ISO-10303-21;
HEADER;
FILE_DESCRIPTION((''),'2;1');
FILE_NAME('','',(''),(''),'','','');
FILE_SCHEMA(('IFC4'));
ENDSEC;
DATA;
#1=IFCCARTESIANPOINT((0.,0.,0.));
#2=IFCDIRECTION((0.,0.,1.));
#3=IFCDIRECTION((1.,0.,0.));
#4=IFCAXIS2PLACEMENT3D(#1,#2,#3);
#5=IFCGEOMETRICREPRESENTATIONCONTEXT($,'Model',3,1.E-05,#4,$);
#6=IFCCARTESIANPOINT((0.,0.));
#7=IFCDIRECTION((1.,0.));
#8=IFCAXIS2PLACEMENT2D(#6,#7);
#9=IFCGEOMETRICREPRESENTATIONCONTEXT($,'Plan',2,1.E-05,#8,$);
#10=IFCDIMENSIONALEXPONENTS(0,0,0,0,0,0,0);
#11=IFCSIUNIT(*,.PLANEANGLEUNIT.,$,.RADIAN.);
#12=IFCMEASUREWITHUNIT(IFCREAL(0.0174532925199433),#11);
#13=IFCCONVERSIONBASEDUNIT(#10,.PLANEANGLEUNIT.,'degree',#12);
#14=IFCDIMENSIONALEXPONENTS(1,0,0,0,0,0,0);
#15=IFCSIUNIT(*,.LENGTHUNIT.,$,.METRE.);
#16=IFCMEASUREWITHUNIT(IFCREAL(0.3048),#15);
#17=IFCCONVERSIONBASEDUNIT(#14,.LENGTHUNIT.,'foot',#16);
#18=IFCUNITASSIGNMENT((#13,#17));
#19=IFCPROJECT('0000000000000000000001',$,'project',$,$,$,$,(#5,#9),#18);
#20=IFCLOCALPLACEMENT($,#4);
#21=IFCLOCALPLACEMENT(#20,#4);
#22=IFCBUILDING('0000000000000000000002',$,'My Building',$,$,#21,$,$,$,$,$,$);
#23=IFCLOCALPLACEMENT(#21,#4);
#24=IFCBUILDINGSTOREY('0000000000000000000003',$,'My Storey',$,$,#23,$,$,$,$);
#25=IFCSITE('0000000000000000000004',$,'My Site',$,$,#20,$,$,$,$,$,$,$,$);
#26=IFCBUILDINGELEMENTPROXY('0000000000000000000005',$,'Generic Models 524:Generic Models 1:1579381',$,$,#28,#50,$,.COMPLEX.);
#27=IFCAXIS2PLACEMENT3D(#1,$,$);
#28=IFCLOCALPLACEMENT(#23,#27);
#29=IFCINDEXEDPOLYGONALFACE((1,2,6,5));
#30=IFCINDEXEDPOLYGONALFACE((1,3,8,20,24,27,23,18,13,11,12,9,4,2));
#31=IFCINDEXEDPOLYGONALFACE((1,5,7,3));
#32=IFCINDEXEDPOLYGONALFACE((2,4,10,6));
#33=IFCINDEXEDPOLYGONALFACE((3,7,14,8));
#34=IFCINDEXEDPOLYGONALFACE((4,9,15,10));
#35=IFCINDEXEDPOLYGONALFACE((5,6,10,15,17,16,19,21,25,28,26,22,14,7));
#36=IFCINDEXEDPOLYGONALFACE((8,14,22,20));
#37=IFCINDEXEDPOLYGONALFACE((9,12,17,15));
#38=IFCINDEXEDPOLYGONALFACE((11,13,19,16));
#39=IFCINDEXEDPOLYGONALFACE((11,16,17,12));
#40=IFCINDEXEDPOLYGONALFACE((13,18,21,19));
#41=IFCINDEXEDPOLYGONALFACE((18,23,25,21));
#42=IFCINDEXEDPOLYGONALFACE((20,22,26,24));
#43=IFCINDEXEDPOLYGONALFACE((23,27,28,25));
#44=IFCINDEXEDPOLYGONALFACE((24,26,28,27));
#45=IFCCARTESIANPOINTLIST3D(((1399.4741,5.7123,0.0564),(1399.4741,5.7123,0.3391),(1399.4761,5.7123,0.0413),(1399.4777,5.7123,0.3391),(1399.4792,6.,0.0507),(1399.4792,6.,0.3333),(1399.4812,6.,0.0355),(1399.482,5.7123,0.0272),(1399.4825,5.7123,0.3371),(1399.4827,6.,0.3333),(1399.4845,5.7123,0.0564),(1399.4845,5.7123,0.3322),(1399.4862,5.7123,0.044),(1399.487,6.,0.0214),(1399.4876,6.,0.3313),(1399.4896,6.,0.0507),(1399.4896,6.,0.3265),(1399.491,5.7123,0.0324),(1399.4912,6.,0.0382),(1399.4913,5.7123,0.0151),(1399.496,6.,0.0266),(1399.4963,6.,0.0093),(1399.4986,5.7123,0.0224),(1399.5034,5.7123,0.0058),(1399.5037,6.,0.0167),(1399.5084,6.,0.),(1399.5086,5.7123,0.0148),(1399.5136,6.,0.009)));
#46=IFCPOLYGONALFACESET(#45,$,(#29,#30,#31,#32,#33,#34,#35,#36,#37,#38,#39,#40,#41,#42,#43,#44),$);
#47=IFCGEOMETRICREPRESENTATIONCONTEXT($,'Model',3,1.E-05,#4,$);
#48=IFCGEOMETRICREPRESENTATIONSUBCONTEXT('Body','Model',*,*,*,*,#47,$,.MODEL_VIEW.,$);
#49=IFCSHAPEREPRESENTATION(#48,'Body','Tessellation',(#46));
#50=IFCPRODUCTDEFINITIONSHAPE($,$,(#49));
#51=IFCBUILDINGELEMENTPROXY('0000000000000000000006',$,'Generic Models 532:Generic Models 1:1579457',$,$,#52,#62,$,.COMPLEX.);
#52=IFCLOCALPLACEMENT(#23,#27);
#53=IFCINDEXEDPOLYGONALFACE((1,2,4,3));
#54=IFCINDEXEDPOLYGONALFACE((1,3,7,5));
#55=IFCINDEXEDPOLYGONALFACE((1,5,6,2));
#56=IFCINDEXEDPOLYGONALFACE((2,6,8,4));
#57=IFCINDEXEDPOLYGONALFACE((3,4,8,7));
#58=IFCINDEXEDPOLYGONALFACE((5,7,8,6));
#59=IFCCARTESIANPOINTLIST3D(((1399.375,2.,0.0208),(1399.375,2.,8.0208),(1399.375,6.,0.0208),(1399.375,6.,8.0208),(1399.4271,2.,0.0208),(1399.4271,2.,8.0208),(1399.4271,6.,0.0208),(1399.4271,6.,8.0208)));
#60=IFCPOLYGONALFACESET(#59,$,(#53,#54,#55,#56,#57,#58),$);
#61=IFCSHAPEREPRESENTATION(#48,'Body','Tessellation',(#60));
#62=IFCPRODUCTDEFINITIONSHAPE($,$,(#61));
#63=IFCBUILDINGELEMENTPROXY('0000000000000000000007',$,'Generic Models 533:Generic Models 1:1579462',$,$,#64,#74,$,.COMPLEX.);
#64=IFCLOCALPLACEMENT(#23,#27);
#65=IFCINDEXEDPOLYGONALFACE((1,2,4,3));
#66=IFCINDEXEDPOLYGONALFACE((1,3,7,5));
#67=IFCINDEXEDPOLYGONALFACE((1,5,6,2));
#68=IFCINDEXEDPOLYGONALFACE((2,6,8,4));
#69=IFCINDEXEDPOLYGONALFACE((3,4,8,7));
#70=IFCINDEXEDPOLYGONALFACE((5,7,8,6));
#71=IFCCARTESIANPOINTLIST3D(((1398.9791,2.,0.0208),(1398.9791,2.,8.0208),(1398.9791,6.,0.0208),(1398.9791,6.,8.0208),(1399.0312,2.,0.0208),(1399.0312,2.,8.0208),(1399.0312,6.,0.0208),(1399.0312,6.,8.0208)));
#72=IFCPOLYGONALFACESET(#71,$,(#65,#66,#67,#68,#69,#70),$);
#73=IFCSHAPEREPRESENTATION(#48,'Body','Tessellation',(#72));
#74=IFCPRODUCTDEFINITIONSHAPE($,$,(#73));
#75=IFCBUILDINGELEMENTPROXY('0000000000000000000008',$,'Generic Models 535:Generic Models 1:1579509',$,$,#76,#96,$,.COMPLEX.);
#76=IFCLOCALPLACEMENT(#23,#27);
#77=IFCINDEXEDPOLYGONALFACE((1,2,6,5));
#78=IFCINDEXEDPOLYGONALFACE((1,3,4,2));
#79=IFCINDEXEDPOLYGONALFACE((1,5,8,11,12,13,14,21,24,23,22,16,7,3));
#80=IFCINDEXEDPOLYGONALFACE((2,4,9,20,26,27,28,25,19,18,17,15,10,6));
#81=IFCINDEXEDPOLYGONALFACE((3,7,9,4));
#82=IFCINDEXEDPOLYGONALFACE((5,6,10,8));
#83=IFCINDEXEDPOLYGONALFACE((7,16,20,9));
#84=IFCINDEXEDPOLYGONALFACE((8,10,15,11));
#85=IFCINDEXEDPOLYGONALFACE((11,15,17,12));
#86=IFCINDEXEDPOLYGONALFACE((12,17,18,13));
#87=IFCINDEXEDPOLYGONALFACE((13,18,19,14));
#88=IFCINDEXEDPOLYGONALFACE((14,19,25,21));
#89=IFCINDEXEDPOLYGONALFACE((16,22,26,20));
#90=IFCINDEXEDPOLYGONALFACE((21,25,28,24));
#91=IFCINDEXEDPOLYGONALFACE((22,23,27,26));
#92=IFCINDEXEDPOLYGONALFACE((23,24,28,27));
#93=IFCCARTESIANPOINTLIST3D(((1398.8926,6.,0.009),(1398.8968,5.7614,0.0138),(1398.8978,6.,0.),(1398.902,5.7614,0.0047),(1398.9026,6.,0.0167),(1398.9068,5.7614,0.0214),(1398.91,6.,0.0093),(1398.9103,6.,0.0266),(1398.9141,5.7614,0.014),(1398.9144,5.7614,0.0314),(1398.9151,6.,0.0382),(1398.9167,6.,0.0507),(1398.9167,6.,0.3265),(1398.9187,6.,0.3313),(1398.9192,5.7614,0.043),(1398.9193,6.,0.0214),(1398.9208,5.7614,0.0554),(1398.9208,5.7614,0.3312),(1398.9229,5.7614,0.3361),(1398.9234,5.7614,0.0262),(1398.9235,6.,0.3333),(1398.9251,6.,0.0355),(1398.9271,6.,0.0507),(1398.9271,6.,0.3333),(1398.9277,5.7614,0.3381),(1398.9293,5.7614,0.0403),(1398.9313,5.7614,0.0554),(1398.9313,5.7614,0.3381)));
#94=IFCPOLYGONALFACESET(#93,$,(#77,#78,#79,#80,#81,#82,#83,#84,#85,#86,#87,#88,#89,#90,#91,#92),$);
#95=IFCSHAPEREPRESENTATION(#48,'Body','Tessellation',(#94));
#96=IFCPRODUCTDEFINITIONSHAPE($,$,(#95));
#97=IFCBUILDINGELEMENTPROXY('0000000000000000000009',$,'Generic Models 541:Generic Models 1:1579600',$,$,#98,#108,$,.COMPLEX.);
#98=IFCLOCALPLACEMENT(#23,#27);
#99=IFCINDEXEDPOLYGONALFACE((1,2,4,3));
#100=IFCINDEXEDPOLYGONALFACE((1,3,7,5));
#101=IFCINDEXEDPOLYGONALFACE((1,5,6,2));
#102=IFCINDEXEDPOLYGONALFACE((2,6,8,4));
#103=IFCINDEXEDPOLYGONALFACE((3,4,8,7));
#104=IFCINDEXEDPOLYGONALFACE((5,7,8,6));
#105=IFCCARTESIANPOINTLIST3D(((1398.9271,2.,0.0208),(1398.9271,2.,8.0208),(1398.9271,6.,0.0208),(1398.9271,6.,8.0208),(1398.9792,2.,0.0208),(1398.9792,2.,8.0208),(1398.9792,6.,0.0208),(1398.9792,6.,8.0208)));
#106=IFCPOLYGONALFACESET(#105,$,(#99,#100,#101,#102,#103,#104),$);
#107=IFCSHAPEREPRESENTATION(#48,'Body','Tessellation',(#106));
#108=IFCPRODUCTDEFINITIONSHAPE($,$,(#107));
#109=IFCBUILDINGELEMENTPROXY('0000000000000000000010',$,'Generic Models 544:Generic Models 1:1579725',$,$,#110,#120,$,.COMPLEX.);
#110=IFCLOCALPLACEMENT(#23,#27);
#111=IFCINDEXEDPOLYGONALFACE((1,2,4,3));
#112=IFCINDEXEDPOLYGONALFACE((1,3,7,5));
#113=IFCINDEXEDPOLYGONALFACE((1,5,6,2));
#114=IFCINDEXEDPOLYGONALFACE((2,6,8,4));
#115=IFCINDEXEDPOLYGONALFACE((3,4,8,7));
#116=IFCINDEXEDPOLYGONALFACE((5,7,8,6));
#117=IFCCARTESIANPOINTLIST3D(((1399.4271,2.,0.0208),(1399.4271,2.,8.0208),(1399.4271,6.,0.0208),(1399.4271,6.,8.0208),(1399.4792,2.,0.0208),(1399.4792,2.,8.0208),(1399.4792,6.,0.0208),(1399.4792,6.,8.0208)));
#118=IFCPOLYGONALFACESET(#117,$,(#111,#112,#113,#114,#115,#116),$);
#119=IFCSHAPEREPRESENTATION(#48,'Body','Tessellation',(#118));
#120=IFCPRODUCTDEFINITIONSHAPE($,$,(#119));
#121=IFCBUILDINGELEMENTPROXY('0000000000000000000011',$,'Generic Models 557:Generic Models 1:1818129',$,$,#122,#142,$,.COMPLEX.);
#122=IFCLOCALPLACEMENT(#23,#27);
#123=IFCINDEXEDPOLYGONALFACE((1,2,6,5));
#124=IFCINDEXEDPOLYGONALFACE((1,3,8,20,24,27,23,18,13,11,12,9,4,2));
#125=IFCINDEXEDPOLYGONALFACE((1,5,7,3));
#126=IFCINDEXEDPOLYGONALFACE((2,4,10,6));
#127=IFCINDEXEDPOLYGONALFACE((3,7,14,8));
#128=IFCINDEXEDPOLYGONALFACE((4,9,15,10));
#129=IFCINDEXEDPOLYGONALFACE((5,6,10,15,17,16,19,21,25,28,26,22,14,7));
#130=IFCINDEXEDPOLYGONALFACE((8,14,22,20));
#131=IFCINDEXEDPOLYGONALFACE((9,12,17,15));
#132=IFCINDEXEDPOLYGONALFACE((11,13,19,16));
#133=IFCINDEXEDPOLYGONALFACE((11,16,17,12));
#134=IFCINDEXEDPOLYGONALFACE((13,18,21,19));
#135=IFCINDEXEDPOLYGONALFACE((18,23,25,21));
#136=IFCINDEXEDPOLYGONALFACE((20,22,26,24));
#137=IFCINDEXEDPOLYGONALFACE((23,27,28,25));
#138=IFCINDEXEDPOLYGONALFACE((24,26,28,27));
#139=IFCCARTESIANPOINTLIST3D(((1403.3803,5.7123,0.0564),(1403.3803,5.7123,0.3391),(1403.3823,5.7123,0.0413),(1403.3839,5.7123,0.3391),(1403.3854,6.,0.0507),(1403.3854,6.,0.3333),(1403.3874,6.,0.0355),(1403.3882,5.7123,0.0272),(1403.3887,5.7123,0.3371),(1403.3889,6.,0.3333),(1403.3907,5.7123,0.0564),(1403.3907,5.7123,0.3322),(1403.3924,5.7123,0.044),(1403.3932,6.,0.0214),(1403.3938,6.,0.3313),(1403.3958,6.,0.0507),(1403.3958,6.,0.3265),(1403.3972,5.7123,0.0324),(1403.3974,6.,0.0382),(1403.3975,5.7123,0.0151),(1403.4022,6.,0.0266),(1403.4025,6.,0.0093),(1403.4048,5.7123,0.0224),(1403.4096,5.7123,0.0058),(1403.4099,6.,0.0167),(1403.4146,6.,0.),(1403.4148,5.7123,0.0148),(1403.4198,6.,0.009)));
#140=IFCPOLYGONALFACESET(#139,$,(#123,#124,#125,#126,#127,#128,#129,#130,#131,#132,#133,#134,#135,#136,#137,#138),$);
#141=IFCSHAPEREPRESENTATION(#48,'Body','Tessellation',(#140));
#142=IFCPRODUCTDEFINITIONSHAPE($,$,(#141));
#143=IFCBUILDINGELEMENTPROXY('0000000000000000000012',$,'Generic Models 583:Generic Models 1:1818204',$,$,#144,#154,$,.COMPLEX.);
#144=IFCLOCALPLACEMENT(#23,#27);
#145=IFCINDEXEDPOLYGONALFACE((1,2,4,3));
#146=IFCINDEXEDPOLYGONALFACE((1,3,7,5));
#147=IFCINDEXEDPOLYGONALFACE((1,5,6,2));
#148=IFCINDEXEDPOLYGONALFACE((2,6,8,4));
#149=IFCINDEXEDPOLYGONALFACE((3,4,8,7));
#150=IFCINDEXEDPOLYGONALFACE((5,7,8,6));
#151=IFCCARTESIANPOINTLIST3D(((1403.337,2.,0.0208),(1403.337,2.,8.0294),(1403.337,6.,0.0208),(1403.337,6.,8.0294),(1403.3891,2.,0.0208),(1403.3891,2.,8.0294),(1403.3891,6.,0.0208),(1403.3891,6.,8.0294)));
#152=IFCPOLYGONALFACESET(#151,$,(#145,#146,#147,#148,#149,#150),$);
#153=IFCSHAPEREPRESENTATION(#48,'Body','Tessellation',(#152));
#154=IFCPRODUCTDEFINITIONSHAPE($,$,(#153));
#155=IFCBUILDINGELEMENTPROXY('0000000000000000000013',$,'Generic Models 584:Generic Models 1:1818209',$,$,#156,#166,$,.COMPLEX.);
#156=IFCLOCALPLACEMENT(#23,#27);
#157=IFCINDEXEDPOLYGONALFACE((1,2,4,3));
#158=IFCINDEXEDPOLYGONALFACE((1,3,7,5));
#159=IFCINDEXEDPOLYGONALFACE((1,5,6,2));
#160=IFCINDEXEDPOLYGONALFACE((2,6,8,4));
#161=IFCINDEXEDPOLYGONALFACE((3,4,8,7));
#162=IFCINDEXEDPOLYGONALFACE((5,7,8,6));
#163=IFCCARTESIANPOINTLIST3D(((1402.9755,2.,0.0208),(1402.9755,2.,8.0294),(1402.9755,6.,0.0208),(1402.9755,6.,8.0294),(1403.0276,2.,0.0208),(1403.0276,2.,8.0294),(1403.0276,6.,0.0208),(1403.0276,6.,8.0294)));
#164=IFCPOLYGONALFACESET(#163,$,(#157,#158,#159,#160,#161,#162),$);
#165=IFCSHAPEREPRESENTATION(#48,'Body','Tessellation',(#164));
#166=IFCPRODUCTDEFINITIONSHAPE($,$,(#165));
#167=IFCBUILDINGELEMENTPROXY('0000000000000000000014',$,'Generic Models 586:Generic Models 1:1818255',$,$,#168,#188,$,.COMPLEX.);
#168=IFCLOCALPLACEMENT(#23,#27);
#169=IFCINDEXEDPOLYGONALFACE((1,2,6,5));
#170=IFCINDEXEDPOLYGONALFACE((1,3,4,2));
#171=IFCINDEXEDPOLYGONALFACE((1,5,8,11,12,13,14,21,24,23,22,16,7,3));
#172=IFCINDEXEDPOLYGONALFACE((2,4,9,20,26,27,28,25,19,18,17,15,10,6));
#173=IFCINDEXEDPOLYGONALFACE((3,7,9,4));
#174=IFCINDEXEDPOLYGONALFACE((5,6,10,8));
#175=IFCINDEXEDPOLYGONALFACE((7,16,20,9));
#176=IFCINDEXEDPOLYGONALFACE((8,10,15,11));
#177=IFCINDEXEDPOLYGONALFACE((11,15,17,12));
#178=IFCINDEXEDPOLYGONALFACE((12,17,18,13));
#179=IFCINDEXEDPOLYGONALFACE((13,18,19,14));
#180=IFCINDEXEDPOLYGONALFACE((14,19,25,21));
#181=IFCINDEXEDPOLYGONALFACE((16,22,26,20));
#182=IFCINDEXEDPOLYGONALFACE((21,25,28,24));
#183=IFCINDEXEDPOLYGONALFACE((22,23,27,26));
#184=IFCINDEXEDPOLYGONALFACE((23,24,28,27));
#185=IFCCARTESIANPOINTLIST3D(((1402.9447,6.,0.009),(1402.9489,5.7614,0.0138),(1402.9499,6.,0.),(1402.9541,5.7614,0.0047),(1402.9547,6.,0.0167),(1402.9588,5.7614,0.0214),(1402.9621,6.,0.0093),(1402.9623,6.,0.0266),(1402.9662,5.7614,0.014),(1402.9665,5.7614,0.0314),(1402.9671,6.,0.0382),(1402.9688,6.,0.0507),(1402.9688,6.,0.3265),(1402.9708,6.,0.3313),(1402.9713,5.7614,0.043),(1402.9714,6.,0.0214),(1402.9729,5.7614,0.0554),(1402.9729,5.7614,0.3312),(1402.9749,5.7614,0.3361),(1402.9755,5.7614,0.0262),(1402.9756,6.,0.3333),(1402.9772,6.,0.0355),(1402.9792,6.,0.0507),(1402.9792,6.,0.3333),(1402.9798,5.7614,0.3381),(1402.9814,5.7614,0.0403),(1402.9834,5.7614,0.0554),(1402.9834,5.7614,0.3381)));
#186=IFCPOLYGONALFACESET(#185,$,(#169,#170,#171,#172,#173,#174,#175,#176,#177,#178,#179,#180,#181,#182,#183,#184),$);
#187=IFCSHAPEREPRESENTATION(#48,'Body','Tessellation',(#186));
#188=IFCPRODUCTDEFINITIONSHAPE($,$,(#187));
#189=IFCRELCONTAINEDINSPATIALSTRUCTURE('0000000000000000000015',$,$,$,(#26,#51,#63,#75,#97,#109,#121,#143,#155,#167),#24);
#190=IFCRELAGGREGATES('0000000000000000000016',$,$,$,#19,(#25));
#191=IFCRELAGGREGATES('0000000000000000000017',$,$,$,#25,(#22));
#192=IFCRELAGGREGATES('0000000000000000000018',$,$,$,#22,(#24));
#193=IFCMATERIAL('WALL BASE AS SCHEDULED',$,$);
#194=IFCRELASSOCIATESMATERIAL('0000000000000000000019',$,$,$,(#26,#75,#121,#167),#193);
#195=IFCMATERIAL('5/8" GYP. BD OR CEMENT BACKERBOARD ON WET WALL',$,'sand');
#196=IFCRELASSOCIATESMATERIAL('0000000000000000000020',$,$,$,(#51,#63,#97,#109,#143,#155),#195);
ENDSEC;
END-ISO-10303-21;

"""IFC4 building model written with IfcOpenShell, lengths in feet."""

from ifc_helpers import new_model, entity, si_unit, converted_unit, frame, origin_with_axes, origin_2d_with_axis, place, context, subcontext, project, spatial, polyline, outline, extrude, material, element, save


model = new_model("IFC4")

# Units and contexts
model_context_1 = context("Model", 3, precision=1e-05, world=origin_with_axes())
plan_context = context("Plan", 2, precision=1e-05, world=origin_2d_with_axis())
model_context_2 = context("Model", 3, precision=1e-05, world=origin_with_axes())
body_context = subcontext(model_context_2, "Body", "Model", "MODEL_VIEW")
ifc_project = project(units=[converted_unit("PLANEANGLEUNIT", "degree", entity("IfcReal", 0.0174532925199433), si_unit("PLANEANGLEUNIT", "RADIAN"), dimensions=[0, 0, 0, 0, 0, 0, 0]), converted_unit("LENGTHUNIT", "foot", entity("IfcReal", 0.3048), si_unit("LENGTHUNIT", "METRE"), dimensions=[1, 0, 0, 0, 0, 0, 0])], contexts=[model_context_1, plan_context])

# Site, building, storey
site_placement = place(None, origin_with_axes())
site = spatial("IfcSite", under=ifc_project, at=site_placement, Name="My Site")
building_placement = place(site_placement, origin_with_axes())
building = spatial("IfcBuilding", under=site, at=building_placement, Name="My Building")
storey_placement = place(building_placement, origin_with_axes())
storey = spatial("IfcBuildingStorey", under=building, at=storey_placement, Name="My Storey")

# Building element proxies
ifc_material_1 = material(Name="WALL BASE AS SCHEDULED")
proxy_1_placement = place(storey_placement, frame((1399.4792, 6.0, 0.0), z_axis=(0.0, -1.0, 0.0), x_axis=(0.0, 0.0, 1.0)))
element("IfcBuildingElementProxy", 1, at=proxy_1_placement, inside=storey, material=ifc_material_1, Name="Generic Models 524:Generic Models 1:1579381", PredefinedType="COMPLEX", context=body_context, shape_type="SweptSolid", body=[
    extrude(outline(polyline([(0.0865, 0.0), (0.0968, -0.0072), (0.105, -0.0167), (0.1137, -0.0111), (0.1038, 0.0006), (0.0913, 0.0093), (0.0769, 0.0144), (0.0617, 0.0157), (-0.2206, 0.0019), (-0.2205, -0.0017), (-0.2182, -0.0064), (-0.2133, -0.0082), (0.0622, 0.0053), (0.0747, 0.0042), (0.0865, 0.0)])), frame((0.113, -0.0126, 0.0), z_axis=(0.0, 0.0, -1.0), x_axis=(-0.998808, -0.048806, 0.0)), (-0.020832, 0.016543, -0.999646), 0.2878),
])
ifc_material_2 = material(Name="5/8\" GYP. BD OR CEMENT BACKERBOARD ON WET WALL", Category="sand")
proxy_2_placement = place(storey_placement, frame((1399.375, 6.0, 0.0208), z_axis=(0.0, -1.0, 0.0), x_axis=(0.0, 0.0, 1.0)))
element("IfcBuildingElementProxy", 2, at=proxy_2_placement, inside=storey, material=ifc_material_2, Name="Generic Models 532:Generic Models 1:1579457", PredefinedType="COMPLEX", context=body_context, shape_type="SweptSolid", body=[
    extrude(outline(polyline([(-4.0, -0.026), (4.0, -0.026), (4.0, 0.026), (-4.0, 0.026), (-4.0, -0.026)])), frame((4.0, -0.026, 0.0), z_axis=(0.0, 0.0, -1.0), x_axis=(1.0, 0.0, 0.0)), (0.0, 0.0, -1.0), 4.0),
])
proxy_3_placement = place(storey_placement, frame((1398.9791, 6.0, 0.0208), z_axis=(0.0, -1.0, 0.0), x_axis=(0.0, 0.0, 1.0)))
element("IfcBuildingElementProxy", 3, at=proxy_3_placement, inside=storey, material=ifc_material_2, Name="Generic Models 533:Generic Models 1:1579462", PredefinedType="COMPLEX", context=body_context, shape_type="SweptSolid", body=[
    extrude(outline(polyline([(-0.026, -4.0), (0.026, -4.0), (0.026, 4.0), (-0.026, 4.0), (-0.026, -4.0)])), frame((4.0, -0.026, 0.0), z_axis=(0.0, 0.0, -1.0), x_axis=(0.0, -1.0, 0.0)), (0.0, 0.0, -1.0), 4.0),
])
proxy_4_placement = place(storey_placement, frame((1398.8926, 6.0, 0.0), z_axis=(0.0, -1.0, 0.0), x_axis=(0.0, 0.0, 1.0)))
element("IfcBuildingElementProxy", 4, at=proxy_4_placement, inside=storey, material=ifc_material_1, Name="Generic Models 535:Generic Models 1:1579509", PredefinedType="COMPLEX", context=body_context, shape_type="SweptSolid", body=[
    extrude(outline(polyline([(-0.2203, -0.0126), (0.0624, -0.0126), (0.0775, -0.0106), (0.0916, -0.0048), (0.1037, 0.0045), (0.113, 0.0166), (0.104, 0.0218), (0.0964, 0.0119), (0.0864, 0.0042), (0.0748, -0.0006), (0.0624, -0.0022), (-0.2134, -0.0022), (-0.2183, -0.0042), (-0.2203, -0.0091), (-0.2203, -0.0126)])), frame((0.113, -0.0218, 0.0), z_axis=(0.0, 0.0, -1.0), x_axis=(-1.0, 0.0, 0.0)), (-0.01982, -0.017382, -0.999652), 0.2387),
])
for number, where, z_axis, x_axis, name in (
    (5, (1398.9271, 6.0, 0.0208), (0.0, -1.0, 0.0), (0.0, 0.0, 1.0), "Generic Models 541:Generic Models 1:1579600"),
    (6, (1399.4271, 6.0, 0.0208), (0.0, -1.0, 0.0), (0.0, 0.0, 1.0), "Generic Models 544:Generic Models 1:1579725"),
):
    element("IfcBuildingElementProxy", number, at=place(storey_placement, frame(where, z_axis=z_axis, x_axis=x_axis)), inside=storey, material=ifc_material_2, Name=name, PredefinedType="COMPLEX", context=body_context, shape_type="SweptSolid", body=[
        extrude(outline(polyline([(-4.0, -0.026), (4.0, -0.026), (4.0, 0.026), (-4.0, 0.026), (-4.0, -0.026)])), frame((4.0, -0.026, 0.0), z_axis=(0.0, 0.0, -1.0), x_axis=(1.0, 0.0, 0.0)), (0.0, 0.0, -1.0), 4.0),
    ])
proxy_5_placement = place(storey_placement, frame((1403.3854, 6.0, 0.0), z_axis=(0.0, -1.0, 0.0), x_axis=(0.0, 0.0, 1.0)))
element("IfcBuildingElementProxy", 7, at=proxy_5_placement, inside=storey, material=ifc_material_1, Name="Generic Models 557:Generic Models 1:1818129", PredefinedType="COMPLEX", context=body_context, shape_type="SweptSolid", body=[
    extrude(outline(polyline([(0.1038, 0.0), (0.0913, 0.0088), (0.077, 0.014), (0.0618, 0.0153), (-0.2206, 0.0031), (-0.2205, -0.0005), (-0.2183, -0.0052), (-0.2133, -0.007), (0.0622, 0.0049), (0.0747, 0.0038), (0.0865, -0.0005), (0.0968, -0.0077), (0.1049, -0.0173), (0.1137, -0.0117), (0.1038, 0.0)])), frame((0.113, -0.0126, 0.0), z_axis=(0.0, 0.0, -1.0), x_axis=(-0.999059, -0.043362, 0.0)), (-0.020742, 0.016656, -0.999646), 0.2878),
])
proxy_6_placement = place(storey_placement, frame((1403.337, 6.0, 0.0208), z_axis=(0.0, -1.0, 0.0), x_axis=(0.0, 0.0, 1.0)))
element("IfcBuildingElementProxy", 8, at=proxy_6_placement, inside=storey, material=ifc_material_2, Name="Generic Models 583:Generic Models 1:1818204", PredefinedType="COMPLEX", context=body_context, shape_type="SweptSolid", body=[
    extrude(outline(polyline([(-4.0043, -0.026), (4.0043, -0.026), (4.0043, 0.026), (-4.0043, 0.026), (-4.0043, -0.026)])), frame((4.0043, -0.026, 0.0), z_axis=(0.0, 0.0, -1.0), x_axis=(-1.0, 0.0, 0.0)), (0.0, 0.0, -1.0), 4.0),
])
proxy_7_placement = place(storey_placement, frame((1402.9755, 6.0, 0.0208), z_axis=(0.0, -1.0, 0.0), x_axis=(0.0, 0.0, 1.0)))
element("IfcBuildingElementProxy", 9, at=proxy_7_placement, inside=storey, material=ifc_material_2, Name="Generic Models 584:Generic Models 1:1818209", PredefinedType="COMPLEX", context=body_context, shape_type="SweptSolid", body=[
    extrude(outline(polyline([(-0.026, -4.0043), (0.026, -4.0043), (0.026, 4.0043), (-0.026, 4.0043), (-0.026, -4.0043)])), frame((4.0043, -0.026, 0.0), z_axis=(0.0, 0.0, -1.0), x_axis=(0.0, 1.0, 0.0)), (0.0, 0.0, -1.0), 4.0),
])
proxy_8_placement = place(storey_placement, frame((1402.9447, 6.0, 0.0), z_axis=(0.0, -1.0, 0.0), x_axis=(0.0, 0.0, 1.0)))
element("IfcBuildingElementProxy", 10, at=proxy_8_placement, inside=storey, material=ifc_material_1, Name="Generic Models 586:Generic Models 1:1818255", PredefinedType="COMPLEX", context=body_context, shape_type="SweptSolid", body=[
    extrude(outline(polyline([(0.0748, 0.0), (0.0624, -0.0017), (-0.2134, -0.0039), (-0.2182, -0.0059), (-0.2202, -0.0108), (-0.2202, -0.0144), (0.0625, -0.0122), (0.0776, -0.01), (0.0917, -0.0041), (0.1037, 0.0053), (0.1129, 0.0175), (0.1039, 0.0226), (0.0963, 0.0126), (0.0864, 0.0049), (0.0748, 0.0)])), frame((0.113, -0.0218, 0.0), z_axis=(0.0, 0.0, -1.0), x_axis=(-0.99997, -0.007803, 0.0)), (-0.019684, -0.017536, -0.999652), 0.2387),
])

save(model, "model.ifc")
